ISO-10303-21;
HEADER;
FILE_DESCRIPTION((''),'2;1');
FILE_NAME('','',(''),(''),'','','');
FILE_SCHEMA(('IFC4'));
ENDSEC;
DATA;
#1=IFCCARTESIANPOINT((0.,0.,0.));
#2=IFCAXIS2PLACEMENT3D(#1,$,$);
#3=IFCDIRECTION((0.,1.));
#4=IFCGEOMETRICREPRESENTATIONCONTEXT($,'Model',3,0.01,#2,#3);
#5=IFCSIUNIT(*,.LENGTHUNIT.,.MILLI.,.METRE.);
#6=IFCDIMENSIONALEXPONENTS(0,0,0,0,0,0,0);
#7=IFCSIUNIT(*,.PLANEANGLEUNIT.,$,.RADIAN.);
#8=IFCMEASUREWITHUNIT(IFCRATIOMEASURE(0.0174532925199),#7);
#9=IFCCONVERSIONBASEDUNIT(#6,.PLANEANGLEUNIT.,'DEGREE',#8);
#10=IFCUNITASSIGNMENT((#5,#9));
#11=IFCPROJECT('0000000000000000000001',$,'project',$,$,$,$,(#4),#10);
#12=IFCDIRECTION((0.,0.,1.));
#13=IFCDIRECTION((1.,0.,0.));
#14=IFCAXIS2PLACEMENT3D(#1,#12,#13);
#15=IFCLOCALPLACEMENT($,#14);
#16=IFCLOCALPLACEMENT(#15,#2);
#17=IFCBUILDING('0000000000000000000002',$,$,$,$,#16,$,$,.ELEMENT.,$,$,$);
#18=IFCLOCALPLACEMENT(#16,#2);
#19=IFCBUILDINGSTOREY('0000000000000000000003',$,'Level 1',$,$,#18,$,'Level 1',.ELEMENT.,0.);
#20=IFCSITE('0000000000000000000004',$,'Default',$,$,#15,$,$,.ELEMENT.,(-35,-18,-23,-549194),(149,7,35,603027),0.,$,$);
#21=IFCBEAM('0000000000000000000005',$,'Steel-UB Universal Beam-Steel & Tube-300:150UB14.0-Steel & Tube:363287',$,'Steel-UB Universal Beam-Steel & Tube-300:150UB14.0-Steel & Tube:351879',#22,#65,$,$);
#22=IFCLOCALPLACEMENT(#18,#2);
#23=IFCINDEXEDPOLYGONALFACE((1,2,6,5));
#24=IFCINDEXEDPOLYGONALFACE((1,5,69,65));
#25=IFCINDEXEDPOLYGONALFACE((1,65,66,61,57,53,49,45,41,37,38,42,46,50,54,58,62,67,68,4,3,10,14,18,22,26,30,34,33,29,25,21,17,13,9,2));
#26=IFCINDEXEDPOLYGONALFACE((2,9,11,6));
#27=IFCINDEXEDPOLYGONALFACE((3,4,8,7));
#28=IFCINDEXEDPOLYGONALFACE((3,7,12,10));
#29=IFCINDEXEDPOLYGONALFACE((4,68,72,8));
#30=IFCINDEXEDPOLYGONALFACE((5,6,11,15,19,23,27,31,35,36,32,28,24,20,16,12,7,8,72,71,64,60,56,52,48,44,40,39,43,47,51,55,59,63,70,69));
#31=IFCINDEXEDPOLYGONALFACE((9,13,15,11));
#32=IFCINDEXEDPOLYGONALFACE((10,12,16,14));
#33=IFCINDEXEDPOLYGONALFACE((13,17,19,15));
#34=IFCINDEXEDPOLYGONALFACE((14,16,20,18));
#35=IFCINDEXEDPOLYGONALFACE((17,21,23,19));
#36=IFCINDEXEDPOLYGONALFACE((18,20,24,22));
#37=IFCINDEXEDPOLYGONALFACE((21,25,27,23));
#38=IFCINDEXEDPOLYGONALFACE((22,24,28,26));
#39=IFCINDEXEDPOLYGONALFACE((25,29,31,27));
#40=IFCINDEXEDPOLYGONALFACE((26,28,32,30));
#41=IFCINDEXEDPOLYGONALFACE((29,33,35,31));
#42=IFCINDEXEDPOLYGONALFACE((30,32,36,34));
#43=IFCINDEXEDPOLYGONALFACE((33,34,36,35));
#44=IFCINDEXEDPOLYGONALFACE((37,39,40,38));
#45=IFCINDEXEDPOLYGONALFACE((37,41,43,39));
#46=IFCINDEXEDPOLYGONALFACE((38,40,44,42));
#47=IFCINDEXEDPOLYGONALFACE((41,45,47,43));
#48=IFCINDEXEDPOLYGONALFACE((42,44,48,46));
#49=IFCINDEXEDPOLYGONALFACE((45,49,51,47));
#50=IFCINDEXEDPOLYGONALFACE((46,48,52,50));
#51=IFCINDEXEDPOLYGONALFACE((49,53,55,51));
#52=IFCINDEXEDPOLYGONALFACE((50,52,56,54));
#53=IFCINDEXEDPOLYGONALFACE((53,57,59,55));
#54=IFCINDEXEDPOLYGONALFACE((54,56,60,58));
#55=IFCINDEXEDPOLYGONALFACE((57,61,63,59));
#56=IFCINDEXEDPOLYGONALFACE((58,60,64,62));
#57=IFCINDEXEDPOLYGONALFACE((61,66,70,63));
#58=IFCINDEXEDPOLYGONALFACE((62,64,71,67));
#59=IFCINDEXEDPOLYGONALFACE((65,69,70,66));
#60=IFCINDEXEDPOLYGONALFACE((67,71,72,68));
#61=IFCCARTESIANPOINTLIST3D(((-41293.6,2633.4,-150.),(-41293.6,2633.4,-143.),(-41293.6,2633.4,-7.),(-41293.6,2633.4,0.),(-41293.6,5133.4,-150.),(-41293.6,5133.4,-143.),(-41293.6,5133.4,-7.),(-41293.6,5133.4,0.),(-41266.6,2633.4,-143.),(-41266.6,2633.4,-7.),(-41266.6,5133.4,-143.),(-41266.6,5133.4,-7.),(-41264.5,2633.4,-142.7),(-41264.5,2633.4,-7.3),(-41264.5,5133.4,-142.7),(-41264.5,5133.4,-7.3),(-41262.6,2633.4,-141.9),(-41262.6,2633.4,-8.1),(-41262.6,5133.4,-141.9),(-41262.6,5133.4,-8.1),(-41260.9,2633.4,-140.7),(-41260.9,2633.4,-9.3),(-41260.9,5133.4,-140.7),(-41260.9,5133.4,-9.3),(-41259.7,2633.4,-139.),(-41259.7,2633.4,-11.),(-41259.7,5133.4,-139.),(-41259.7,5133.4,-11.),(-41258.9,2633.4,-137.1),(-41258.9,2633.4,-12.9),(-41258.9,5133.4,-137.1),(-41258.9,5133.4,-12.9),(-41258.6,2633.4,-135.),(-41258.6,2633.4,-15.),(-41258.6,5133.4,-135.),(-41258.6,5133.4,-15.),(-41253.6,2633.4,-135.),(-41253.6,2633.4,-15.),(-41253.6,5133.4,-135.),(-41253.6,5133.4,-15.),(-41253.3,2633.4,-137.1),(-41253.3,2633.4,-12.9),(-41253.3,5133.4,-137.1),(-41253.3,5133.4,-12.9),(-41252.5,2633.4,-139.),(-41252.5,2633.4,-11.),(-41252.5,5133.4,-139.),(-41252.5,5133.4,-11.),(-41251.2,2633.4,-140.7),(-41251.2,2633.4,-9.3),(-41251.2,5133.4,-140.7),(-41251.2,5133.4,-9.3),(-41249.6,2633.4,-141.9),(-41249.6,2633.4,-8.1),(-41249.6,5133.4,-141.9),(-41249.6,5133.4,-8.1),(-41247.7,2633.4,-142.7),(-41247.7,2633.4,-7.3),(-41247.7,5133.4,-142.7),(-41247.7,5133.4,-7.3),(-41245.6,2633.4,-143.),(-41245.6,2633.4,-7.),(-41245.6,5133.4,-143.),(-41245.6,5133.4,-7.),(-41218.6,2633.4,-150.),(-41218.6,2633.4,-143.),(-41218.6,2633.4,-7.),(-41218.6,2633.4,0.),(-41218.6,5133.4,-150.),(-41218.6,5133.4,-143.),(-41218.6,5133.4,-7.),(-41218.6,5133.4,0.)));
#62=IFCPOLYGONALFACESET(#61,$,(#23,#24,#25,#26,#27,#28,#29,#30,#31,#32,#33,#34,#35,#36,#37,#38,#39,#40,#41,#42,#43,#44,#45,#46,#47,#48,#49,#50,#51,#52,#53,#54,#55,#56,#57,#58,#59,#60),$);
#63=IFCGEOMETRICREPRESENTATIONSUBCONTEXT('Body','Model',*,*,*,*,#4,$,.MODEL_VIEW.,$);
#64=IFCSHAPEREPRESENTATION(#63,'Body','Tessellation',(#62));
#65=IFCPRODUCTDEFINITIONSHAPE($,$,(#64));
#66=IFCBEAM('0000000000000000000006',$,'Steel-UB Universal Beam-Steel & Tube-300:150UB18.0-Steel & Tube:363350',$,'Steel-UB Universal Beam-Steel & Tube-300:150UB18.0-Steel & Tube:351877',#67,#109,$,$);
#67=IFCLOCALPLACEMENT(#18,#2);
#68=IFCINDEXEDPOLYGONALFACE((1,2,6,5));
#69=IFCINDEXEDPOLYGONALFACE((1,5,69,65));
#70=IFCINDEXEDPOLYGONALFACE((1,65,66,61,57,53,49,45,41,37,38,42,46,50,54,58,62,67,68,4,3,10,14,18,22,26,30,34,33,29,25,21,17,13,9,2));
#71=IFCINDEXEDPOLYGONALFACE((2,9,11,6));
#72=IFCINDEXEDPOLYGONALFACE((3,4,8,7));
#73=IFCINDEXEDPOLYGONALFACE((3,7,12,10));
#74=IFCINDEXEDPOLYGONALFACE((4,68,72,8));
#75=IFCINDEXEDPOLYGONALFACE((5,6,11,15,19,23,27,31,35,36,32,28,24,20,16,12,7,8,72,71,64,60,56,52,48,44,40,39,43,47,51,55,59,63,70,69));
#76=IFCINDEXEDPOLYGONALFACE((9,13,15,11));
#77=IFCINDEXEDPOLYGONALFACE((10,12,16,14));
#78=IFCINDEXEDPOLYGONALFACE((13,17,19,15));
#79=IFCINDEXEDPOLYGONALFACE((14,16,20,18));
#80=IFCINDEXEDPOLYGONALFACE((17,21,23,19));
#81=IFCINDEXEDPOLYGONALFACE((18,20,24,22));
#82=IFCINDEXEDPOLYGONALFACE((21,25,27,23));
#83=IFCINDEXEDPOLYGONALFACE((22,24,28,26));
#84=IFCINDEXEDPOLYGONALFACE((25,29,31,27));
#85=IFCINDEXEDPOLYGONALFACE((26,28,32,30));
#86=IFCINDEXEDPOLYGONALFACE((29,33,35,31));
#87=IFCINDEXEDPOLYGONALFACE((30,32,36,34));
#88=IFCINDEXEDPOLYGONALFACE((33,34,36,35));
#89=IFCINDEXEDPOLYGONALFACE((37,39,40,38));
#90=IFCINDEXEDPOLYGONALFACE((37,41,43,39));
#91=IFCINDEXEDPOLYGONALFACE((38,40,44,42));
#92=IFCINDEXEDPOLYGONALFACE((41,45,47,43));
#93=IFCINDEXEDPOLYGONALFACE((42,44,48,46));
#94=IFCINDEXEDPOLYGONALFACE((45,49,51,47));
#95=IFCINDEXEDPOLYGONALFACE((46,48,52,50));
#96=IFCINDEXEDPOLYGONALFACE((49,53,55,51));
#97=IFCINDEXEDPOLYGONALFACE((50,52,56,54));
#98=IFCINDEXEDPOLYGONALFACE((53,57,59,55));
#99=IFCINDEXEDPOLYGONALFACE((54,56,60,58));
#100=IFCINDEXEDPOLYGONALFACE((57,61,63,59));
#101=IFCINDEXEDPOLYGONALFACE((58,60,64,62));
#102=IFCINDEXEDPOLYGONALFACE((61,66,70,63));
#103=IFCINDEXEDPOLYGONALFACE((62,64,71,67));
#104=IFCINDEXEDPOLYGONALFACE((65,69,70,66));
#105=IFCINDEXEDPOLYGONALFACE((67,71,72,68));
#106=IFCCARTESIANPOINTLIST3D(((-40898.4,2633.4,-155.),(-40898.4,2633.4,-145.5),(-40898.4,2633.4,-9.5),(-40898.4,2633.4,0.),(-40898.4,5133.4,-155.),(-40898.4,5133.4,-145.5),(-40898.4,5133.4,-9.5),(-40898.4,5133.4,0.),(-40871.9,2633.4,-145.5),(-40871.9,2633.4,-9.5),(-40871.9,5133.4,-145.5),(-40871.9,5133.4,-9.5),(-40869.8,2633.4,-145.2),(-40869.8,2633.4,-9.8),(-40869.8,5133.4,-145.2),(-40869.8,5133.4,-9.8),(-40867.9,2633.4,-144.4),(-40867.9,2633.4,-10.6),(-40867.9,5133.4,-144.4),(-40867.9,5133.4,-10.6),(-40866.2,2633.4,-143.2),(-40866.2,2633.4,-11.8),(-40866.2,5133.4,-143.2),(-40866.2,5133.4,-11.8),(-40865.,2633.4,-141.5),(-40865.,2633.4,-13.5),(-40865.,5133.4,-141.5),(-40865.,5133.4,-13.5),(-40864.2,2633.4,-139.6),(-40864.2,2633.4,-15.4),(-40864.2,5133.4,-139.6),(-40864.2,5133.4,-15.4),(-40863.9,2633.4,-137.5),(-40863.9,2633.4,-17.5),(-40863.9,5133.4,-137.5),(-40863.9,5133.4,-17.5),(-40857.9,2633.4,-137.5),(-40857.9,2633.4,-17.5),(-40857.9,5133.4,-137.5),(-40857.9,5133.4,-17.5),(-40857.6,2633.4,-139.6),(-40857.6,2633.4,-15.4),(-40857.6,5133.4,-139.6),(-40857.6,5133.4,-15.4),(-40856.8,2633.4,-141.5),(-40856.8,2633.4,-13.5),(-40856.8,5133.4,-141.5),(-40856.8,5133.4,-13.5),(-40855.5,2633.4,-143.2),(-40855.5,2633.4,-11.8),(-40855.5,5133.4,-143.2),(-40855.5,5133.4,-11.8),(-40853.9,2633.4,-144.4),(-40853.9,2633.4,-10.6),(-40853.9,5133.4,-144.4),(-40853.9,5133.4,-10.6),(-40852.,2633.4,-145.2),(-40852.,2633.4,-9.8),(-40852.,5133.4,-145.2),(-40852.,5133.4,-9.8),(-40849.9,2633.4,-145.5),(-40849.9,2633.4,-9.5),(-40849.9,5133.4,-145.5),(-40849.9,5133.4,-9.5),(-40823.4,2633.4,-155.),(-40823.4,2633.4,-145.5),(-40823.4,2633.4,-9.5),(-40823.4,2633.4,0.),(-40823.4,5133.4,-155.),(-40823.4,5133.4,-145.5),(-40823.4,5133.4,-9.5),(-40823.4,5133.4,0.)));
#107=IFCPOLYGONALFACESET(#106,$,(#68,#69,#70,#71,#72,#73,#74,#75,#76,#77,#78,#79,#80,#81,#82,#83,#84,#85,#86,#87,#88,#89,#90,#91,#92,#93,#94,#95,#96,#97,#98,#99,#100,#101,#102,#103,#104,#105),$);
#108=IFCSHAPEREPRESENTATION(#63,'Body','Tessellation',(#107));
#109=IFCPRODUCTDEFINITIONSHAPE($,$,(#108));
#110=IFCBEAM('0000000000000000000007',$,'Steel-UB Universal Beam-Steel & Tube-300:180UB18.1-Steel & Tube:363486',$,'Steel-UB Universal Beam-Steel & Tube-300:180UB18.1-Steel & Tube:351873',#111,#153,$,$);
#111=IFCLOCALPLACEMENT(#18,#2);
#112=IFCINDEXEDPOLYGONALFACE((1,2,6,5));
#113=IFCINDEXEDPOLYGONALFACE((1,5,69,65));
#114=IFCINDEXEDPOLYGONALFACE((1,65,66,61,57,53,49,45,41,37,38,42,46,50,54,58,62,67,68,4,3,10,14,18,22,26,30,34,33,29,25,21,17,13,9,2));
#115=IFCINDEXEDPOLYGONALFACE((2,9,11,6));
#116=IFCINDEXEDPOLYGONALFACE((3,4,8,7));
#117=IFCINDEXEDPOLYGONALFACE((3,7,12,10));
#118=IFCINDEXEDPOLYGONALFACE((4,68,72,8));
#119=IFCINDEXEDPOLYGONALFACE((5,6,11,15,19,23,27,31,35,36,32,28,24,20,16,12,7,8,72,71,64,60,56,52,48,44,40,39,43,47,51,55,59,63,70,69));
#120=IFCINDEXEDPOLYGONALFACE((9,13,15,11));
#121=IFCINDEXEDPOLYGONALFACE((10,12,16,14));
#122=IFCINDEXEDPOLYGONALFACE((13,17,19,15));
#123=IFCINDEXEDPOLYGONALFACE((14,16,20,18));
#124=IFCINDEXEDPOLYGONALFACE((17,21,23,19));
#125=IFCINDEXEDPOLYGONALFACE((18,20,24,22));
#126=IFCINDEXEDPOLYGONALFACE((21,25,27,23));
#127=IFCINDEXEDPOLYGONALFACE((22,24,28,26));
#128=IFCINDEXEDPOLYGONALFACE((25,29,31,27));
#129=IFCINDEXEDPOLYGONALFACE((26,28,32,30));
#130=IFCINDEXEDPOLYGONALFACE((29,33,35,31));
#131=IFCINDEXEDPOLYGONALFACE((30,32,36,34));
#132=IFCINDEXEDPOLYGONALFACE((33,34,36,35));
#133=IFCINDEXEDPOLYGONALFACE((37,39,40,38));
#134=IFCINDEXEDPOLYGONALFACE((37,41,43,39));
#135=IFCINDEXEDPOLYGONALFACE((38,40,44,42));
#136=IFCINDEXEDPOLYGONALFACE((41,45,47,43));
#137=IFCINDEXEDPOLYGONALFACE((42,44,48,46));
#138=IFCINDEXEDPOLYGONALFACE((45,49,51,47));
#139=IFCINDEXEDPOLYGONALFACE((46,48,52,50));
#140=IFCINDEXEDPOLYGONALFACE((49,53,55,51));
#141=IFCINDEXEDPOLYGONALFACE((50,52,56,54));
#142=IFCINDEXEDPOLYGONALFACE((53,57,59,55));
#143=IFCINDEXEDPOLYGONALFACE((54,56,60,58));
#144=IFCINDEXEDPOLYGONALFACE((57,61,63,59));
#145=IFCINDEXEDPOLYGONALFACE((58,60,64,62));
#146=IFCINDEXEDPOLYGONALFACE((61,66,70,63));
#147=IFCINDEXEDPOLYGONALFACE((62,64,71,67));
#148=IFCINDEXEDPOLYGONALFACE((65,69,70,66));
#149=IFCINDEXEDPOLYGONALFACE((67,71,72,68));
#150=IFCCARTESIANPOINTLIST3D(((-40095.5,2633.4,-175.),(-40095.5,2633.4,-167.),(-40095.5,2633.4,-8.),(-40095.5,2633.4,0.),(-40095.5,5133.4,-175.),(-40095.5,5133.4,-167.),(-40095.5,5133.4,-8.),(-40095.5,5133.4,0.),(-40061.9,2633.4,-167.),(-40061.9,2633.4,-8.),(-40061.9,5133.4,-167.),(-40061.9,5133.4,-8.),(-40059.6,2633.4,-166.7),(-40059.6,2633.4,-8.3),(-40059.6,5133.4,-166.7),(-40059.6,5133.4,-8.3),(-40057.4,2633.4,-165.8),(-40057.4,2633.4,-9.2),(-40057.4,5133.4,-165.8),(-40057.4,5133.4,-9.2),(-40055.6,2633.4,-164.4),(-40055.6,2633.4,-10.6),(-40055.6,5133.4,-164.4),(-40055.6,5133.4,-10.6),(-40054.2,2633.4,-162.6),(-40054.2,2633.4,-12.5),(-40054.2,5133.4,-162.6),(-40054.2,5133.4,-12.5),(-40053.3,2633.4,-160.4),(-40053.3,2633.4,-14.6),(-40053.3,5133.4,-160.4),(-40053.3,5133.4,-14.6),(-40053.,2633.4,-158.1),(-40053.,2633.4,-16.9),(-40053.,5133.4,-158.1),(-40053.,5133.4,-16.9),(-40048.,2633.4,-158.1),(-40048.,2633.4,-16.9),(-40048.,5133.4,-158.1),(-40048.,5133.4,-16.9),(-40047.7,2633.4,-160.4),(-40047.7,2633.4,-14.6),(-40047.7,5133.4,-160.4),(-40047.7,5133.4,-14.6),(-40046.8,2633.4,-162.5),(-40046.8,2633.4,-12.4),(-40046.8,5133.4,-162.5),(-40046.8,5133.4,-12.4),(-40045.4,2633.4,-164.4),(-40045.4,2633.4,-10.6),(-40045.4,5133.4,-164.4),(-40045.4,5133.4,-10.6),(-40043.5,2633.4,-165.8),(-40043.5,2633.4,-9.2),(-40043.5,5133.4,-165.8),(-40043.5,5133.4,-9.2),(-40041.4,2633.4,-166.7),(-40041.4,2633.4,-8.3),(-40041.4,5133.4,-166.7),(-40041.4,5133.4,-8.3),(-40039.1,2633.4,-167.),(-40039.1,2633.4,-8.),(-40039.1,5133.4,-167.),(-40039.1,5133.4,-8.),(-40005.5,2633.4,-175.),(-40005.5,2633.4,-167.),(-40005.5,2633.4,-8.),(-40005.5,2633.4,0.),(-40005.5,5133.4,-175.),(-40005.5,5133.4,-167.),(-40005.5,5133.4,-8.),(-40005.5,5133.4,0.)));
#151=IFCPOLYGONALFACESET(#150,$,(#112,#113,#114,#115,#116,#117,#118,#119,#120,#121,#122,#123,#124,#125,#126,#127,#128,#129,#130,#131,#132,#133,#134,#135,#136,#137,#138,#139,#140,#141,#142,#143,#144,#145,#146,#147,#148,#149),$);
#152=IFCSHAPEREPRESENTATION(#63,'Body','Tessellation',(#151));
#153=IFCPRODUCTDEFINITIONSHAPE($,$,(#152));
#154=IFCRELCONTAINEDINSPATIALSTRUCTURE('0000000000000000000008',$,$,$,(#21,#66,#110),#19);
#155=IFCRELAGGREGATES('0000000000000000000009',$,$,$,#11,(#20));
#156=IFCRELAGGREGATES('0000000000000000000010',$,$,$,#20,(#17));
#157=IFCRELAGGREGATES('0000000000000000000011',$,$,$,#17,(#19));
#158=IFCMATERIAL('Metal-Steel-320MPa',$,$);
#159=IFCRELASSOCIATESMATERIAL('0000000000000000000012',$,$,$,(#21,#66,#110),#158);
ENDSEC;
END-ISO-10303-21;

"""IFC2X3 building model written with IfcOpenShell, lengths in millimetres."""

from ifc_helpers import new_model, entity, si_unit, converted_unit, direction, frame, frame_2d, origin, origin_with_axes, place, context, subcontext, project, spatial, polyline, circle_curve, parameter, trimmed, segment, composite_curve, outline, extrude, material, element, save


model = new_model("IFC2X3")

# Units and contexts
model_context = context("Model", 3, precision=0.01, world=origin(), true_north=direction((0.0, 1.0)))
body_context = subcontext(model_context, "Body", "Model", "MODEL_VIEW")
ifc_project = project(units=[si_unit("LENGTHUNIT", "METRE", prefix="MILLI"), converted_unit("PLANEANGLEUNIT", "DEGREE", entity("IfcRatioMeasure", 0.0174532925199), si_unit("PLANEANGLEUNIT", "RADIAN"), dimensions=[0, 0, 0, 0, 0, 0, 0])], contexts=[model_context])

# Site, building, storey
site_placement = place(None, origin_with_axes())
site = spatial("IfcSite", under=ifc_project, at=site_placement, Name="Default", CompositionType="ELEMENT", RefLatitude=(-35, -18, -23, -549194), RefLongitude=(149, 7, 35, 603027), RefElevation=0.0)
building_placement = place(site_placement, origin())
building = spatial("IfcBuilding", under=site, at=building_placement, CompositionType="ELEMENT")
storey_placement = place(building_placement, origin())
storey = spatial("IfcBuildingStorey", under=building, at=storey_placement, Name="Level 1", LongName="Level 1", CompositionType="ELEMENT", Elevation=0.0)

# Beams
ifc_material = material(Name="Metal-Steel-320MPa")
beam_1_placement = place(storey_placement, frame((-41256.1, 5133.4, 0.0), z_axis=(0.0, 0.0, 1.0), x_axis=(0.0, -1.0, 0.0)))
element("IfcBeam", 1, at=beam_1_placement, inside=storey, material=ifc_material, Name="Steel-UB Universal Beam-Steel & Tube-300:150UB14.0-Steel & Tube:363287", ObjectType="Steel-UB Universal Beam-Steel & Tube-300:150UB14.0-Steel & Tube:351879", context=body_context, shape_type="SweptSolid", body=[
    extrude(outline(composite_curve([segment(polyline([(68.0, -37.5), (75.0, -37.5)]), True, "CONTINUOUS"), segment(polyline([(75.0, -37.5), (75.0, 37.5)]), True, "CONTINUOUS"), segment(polyline([(75.0, 37.5), (68.0, 37.5)]), True, "CONTINUOUS"), segment(polyline([(68.0, 37.5), (68.0, 10.5)]), True, "CONTINUOUS"), segment(trimmed(circle_curve(frame_2d((60.0, 10.5), x_axis=(1.0, 0.0)), 8.0), [parameter(270.0)], [parameter(0.0)], True, "PARAMETER"), False, "CONTINUOUS"), segment(polyline([(60.0, 2.5), (-60.0, 2.5)]), True, "CONTINUOUS"), segment(trimmed(circle_curve(frame_2d((-60.0, 10.5), x_axis=(0.0, -1.0)), 8.0), [parameter(270.0)], [parameter(0.0)], True, "PARAMETER"), False, "CONTINUOUS"), segment(polyline([(-68.0, 10.5), (-68.0, 37.5)]), True, "CONTINUOUS"), segment(polyline([(-68.0, 37.5), (-75.0, 37.5)]), True, "CONTINUOUS"), segment(polyline([(-75.0, 37.5), (-75.0, -37.5)]), True, "CONTINUOUS"), segment(polyline([(-75.0, -37.5), (-68.0, -37.5)]), True, "CONTINUOUS"), segment(polyline([(-68.0, -37.5), (-68.0, -10.5)]), True, "CONTINUOUS"), segment(trimmed(circle_curve(frame_2d((-60.0, -10.5), x_axis=(-1.0, 0.0)), 8.0), [parameter(270.0)], [parameter(0.0)], True, "PARAMETER"), False, "CONTINUOUS"), segment(polyline([(-60.0, -2.5), (60.0, -2.5)]), True, "CONTINUOUS"), segment(trimmed(circle_curve(frame_2d((60.0, -10.5), x_axis=(0.0, 1.0)), 8.0), [parameter(270.0)], [parameter(0.0)], True, "PARAMETER"), False, "CONTINUOUS"), segment(polyline([(68.0, -10.5), (68.0, -37.5)]), True, "CONTINUOUS")], self_intersect=False)), frame((0.0, 0.0, -75.0), z_axis=(1.0, 0.0, 0.0), x_axis=(0.0, 0.0, -1.0)), (0.0, 0.0, 1.0), 2500.0),
])
beam_2_placement = place(storey_placement, frame((-40860.9, 5133.4, 0.0), z_axis=(0.0, 0.0, 1.0), x_axis=(0.0, -1.0, 0.0)))
element("IfcBeam", 2, at=beam_2_placement, inside=storey, material=ifc_material, Name="Steel-UB Universal Beam-Steel & Tube-300:150UB18.0-Steel & Tube:363350", ObjectType="Steel-UB Universal Beam-Steel & Tube-300:150UB18.0-Steel & Tube:351877", context=body_context, shape_type="SweptSolid", body=[
    extrude(outline(composite_curve([segment(polyline([(68.0, -37.5), (77.5, -37.5)]), True, "CONTINUOUS"), segment(polyline([(77.5, -37.5), (77.5, 37.5)]), True, "CONTINUOUS"), segment(polyline([(77.5, 37.5), (68.0, 37.5)]), True, "CONTINUOUS"), segment(polyline([(68.0, 37.5), (68.0, 11.0)]), True, "CONTINUOUS"), segment(trimmed(circle_curve(frame_2d((60.0, 11.0), x_axis=(1.0, 0.0)), 8.0), [parameter(270.0)], [parameter(0.0)], True, "PARAMETER"), False, "CONTINUOUS"), segment(polyline([(60.0, 3.0), (-60.0, 3.0)]), True, "CONTINUOUS"), segment(trimmed(circle_curve(frame_2d((-60.0, 11.0), x_axis=(0.0, -1.0)), 8.0), [parameter(270.0)], [parameter(0.0)], True, "PARAMETER"), False, "CONTINUOUS"), segment(polyline([(-68.0, 11.0), (-68.0, 37.5)]), True, "CONTINUOUS"), segment(polyline([(-68.0, 37.5), (-77.5, 37.5)]), True, "CONTINUOUS"), segment(polyline([(-77.5, 37.5), (-77.5, -37.5)]), True, "CONTINUOUS"), segment(polyline([(-77.5, -37.5), (-68.0, -37.5)]), True, "CONTINUOUS"), segment(polyline([(-68.0, -37.5), (-68.0, -11.0)]), True, "CONTINUOUS"), segment(trimmed(circle_curve(frame_2d((-60.0, -11.0), x_axis=(-1.0, 0.0)), 8.0), [parameter(270.0)], [parameter(0.0)], True, "PARAMETER"), False, "CONTINUOUS"), segment(polyline([(-60.0, -3.0), (60.0, -3.0)]), True, "CONTINUOUS"), segment(trimmed(circle_curve(frame_2d((60.0, -11.0), x_axis=(0.0, 1.0)), 8.0), [parameter(270.0)], [parameter(0.0)], True, "PARAMETER"), False, "CONTINUOUS"), segment(polyline([(68.0, -11.0), (68.0, -37.5)]), True, "CONTINUOUS")], self_intersect=False)), frame((0.0, 0.0, -77.5), z_axis=(1.0, 0.0, 0.0), x_axis=(0.0, 0.0, -1.0)), (0.0, 0.0, 1.0), 2500.0),
])
beam_3_placement = place(storey_placement, frame((-40050.5, 5133.4, 0.0), z_axis=(0.0, 0.0, 1.0), x_axis=(0.0, -1.0, 0.0)))
element("IfcBeam", 3, at=beam_3_placement, inside=storey, material=ifc_material, Name="Steel-UB Universal Beam-Steel & Tube-300:180UB18.1-Steel & Tube:363486", ObjectType="Steel-UB Universal Beam-Steel & Tube-300:180UB18.1-Steel & Tube:351873", context=body_context, shape_type="SweptSolid", body=[
    extrude(outline(composite_curve([segment(polyline([(79.5, -45.0), (87.5, -45.0)]), True, "CONTINUOUS"), segment(polyline([(87.5, -45.0), (87.5, 45.0)]), True, "CONTINUOUS"), segment(polyline([(87.5, 45.0), (79.5, 45.0)]), True, "CONTINUOUS"), segment(polyline([(79.5, 45.0), (79.5, 11.4)]), True, "CONTINUOUS"), segment(trimmed(circle_curve(frame_2d((70.6, 11.4), x_axis=(1.0, 0.0)), 8.9), [parameter(270.0)], [parameter(0.0)], True, "PARAMETER"), False, "CONTINUOUS"), segment(polyline([(70.6, 2.5), (-70.6, 2.5)]), True, "CONTINUOUS"), segment(trimmed(circle_curve(frame_2d((-70.6, 11.4), x_axis=(0.0, -1.0)), 8.9), [parameter(270.0)], [parameter(0.0)], True, "PARAMETER"), False, "CONTINUOUS"), segment(polyline([(-79.5, 11.4), (-79.5, 45.0)]), True, "CONTINUOUS"), segment(polyline([(-79.5, 45.0), (-87.5, 45.0)]), True, "CONTINUOUS"), segment(polyline([(-87.5, 45.0), (-87.5, -45.0)]), True, "CONTINUOUS"), segment(polyline([(-87.5, -45.0), (-79.5, -45.0)]), True, "CONTINUOUS"), segment(polyline([(-79.5, -45.0), (-79.5, -11.4)]), True, "CONTINUOUS"), segment(trimmed(circle_curve(frame_2d((-70.6, -11.4), x_axis=(-1.0, 0.0)), 8.9), [parameter(270.0)], [parameter(0.0)], True, "PARAMETER"), False, "CONTINUOUS"), segment(polyline([(-70.6, -2.5), (70.6, -2.5)]), True, "CONTINUOUS"), segment(trimmed(circle_curve(frame_2d((70.6, -11.4), x_axis=(0.0, 1.0)), 8.9), [parameter(270.0)], [parameter(0.0)], True, "PARAMETER"), False, "CONTINUOUS"), segment(polyline([(79.5, -11.4), (79.5, -45.0)]), True, "CONTINUOUS")], self_intersect=False)), frame((0.0, 0.0, -87.5), z_axis=(1.0, 0.0, 0.0), x_axis=(0.0, 0.0, -1.0)), (0.0, 0.0, 1.0), 2500.0),
])

save(model, "model.ifc")
